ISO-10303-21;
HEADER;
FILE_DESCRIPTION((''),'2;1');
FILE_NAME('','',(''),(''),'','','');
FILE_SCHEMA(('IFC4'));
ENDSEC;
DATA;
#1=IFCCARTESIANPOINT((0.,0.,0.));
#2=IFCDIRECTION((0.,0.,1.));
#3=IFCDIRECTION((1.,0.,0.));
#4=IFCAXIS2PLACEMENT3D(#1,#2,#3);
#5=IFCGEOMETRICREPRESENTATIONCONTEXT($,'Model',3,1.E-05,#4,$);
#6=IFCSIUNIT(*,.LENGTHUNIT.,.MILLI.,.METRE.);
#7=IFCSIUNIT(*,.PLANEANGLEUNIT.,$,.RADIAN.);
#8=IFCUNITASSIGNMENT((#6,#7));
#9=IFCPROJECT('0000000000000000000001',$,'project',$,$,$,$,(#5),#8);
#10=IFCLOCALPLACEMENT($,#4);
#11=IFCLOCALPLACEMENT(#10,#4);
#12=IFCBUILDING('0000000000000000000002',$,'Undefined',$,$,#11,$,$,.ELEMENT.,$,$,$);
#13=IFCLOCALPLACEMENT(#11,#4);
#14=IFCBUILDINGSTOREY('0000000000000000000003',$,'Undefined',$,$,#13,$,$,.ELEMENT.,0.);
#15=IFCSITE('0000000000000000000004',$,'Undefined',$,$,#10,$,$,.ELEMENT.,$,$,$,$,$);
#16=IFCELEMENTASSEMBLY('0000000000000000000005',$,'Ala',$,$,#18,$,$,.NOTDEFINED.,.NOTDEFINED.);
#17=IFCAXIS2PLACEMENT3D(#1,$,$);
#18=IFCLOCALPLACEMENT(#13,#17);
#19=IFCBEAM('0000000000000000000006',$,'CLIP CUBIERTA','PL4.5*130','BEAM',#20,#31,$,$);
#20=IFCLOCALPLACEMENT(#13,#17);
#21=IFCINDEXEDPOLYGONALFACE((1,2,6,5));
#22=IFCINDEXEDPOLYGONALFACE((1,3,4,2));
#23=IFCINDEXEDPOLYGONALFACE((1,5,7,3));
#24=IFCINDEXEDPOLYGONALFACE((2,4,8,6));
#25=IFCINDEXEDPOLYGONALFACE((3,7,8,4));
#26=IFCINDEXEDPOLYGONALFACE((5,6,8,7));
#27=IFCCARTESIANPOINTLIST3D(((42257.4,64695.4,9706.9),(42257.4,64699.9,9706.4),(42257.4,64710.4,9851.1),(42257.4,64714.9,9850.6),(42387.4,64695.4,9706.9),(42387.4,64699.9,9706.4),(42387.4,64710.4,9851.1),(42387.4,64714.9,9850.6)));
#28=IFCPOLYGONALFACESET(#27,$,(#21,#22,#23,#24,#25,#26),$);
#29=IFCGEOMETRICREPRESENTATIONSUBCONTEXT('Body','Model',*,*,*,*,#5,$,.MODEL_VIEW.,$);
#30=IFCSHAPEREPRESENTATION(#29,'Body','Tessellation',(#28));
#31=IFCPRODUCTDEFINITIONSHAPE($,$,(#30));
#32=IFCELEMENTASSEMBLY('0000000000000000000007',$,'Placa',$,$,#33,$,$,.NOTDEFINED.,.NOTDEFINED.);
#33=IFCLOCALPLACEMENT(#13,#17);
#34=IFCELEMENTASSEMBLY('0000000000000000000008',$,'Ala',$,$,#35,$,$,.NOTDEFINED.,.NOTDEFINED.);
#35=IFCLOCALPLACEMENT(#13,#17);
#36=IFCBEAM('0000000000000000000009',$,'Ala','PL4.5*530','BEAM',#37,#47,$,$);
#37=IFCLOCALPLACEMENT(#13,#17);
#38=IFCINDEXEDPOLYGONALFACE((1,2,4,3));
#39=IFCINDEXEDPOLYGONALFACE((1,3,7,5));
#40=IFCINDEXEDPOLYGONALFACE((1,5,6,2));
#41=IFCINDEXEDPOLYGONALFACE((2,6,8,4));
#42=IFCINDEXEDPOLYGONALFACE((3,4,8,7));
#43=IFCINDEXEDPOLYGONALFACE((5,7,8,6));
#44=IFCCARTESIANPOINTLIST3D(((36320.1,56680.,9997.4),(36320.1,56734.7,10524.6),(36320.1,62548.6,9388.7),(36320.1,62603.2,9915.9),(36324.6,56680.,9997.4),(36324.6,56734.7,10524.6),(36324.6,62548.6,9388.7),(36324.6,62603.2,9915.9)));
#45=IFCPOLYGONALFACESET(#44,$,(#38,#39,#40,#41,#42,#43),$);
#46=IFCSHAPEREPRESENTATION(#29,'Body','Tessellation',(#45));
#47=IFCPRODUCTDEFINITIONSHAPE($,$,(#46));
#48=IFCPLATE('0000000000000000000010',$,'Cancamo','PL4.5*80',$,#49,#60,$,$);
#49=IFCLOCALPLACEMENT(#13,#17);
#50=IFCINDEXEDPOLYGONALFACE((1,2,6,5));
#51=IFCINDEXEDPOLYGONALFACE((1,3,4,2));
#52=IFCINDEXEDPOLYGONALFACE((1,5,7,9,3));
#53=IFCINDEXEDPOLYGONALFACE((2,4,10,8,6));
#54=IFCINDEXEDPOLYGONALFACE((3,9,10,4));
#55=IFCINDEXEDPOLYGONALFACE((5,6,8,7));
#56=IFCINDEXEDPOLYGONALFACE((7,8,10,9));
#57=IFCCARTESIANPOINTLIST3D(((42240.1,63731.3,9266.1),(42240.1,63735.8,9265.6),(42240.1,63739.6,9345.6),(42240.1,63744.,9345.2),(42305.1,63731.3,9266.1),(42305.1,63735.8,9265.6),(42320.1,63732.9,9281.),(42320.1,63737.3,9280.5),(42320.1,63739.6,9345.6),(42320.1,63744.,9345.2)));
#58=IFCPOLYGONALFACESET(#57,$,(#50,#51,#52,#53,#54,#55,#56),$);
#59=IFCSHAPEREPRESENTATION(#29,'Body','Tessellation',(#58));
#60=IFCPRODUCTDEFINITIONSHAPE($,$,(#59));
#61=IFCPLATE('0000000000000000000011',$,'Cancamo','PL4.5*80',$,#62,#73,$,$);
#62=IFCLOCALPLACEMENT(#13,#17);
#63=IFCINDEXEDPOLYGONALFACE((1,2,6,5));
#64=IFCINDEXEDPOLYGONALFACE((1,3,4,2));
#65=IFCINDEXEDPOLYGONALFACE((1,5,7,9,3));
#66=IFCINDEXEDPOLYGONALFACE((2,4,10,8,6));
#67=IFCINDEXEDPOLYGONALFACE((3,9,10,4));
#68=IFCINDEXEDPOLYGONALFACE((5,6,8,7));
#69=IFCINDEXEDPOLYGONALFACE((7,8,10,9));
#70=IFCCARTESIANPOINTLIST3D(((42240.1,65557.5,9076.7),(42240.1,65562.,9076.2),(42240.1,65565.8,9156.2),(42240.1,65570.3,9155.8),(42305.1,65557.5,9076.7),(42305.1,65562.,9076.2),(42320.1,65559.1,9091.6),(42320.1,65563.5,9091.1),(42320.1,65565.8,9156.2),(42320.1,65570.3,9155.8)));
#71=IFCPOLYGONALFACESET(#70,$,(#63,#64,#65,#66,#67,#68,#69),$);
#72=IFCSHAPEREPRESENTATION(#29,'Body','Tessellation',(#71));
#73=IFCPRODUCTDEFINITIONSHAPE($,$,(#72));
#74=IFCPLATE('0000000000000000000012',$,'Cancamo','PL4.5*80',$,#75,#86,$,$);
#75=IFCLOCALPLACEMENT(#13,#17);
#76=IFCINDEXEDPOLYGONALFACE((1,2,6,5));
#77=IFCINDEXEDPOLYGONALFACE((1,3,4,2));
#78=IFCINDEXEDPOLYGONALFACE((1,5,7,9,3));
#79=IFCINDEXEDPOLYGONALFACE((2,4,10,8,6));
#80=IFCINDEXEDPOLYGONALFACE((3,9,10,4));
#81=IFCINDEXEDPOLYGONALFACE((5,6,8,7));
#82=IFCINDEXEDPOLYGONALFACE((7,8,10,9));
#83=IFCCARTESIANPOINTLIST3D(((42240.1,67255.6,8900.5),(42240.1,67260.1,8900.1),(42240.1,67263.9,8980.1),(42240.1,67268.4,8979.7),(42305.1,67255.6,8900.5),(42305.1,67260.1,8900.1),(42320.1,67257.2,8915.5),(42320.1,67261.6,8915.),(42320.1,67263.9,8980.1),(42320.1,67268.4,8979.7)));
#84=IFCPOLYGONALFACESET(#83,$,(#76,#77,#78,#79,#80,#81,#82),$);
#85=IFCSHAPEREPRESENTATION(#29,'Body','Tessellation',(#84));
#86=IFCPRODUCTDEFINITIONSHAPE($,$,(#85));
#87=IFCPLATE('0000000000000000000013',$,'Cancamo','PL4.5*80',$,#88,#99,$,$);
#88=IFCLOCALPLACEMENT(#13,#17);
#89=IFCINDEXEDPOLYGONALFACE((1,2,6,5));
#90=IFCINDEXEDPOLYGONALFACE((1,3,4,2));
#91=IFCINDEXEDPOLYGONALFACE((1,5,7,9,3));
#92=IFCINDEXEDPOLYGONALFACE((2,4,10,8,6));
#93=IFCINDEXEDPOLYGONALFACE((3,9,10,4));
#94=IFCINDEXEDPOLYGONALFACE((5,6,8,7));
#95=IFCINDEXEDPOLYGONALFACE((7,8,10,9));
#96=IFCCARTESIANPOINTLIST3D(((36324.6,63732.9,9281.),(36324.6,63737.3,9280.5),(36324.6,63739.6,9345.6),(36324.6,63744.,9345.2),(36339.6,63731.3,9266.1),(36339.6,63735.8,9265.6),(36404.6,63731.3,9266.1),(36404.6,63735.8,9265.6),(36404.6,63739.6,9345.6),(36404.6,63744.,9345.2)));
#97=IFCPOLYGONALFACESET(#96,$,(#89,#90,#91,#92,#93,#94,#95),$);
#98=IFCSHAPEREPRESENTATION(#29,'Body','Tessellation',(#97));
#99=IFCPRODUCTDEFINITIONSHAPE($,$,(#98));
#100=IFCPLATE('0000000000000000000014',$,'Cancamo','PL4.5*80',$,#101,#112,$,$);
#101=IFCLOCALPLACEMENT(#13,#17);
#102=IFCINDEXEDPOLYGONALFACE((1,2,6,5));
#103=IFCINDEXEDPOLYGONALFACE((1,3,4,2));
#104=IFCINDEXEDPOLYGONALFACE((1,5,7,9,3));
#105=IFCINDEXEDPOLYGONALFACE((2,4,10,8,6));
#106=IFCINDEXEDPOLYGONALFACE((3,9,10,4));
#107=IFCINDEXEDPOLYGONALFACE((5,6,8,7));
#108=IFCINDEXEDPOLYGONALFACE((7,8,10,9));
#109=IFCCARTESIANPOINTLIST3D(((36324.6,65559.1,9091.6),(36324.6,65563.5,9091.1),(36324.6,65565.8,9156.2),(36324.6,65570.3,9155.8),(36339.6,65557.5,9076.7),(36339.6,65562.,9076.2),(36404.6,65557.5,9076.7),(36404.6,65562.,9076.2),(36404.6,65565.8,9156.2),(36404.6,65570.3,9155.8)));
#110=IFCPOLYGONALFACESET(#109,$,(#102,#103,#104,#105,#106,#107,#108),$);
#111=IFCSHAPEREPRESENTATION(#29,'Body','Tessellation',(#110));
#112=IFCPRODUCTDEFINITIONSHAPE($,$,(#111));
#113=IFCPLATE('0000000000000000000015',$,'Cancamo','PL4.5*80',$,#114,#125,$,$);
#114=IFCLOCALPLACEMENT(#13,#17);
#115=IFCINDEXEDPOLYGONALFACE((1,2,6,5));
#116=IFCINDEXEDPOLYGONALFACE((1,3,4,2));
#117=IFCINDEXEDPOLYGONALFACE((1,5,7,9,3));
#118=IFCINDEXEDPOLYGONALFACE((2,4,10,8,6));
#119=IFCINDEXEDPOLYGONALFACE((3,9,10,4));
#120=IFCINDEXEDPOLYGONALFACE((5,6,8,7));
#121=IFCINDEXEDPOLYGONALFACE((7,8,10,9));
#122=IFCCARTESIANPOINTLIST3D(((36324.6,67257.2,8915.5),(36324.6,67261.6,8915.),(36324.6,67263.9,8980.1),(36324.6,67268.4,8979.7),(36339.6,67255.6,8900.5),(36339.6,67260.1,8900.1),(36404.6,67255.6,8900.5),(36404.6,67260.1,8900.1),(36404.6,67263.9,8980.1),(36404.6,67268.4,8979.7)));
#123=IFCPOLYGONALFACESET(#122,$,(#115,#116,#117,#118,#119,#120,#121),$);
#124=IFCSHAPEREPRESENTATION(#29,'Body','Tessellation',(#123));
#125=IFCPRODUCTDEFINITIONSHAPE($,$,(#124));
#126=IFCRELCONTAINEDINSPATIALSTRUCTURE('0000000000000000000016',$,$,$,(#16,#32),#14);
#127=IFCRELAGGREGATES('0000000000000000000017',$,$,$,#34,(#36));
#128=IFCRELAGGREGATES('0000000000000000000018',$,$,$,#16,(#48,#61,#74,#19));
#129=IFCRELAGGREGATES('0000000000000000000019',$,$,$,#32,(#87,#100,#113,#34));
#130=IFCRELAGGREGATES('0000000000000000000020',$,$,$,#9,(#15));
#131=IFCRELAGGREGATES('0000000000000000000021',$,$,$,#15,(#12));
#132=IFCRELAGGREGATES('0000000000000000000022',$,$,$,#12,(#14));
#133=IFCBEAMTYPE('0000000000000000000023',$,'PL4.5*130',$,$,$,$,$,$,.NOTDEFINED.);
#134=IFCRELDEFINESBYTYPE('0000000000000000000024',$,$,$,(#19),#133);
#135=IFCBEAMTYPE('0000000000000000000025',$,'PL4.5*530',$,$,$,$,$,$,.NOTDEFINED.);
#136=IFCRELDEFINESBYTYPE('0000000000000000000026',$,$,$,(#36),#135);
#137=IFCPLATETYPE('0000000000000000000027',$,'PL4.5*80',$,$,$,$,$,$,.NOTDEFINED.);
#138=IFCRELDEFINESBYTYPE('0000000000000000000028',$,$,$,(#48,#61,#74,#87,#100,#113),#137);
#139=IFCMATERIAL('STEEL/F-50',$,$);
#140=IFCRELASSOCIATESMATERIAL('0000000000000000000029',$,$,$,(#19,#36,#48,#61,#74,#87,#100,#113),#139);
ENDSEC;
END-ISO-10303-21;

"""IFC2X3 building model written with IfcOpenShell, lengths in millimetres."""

from ifc_helpers import new_model, si_unit, frame, origin_with_axes, origin_2d_with_axis, place, context, subcontext, project, spatial, polyline, rectangle, outline, extrude, clip, halfspace, material, type_object, element, aggregate, save


model = new_model("IFC2X3")

# Units and contexts
model_context = context("Model", 3, precision=1e-05, world=origin_with_axes())
body_context = subcontext(model_context, "Body", "Model", "MODEL_VIEW")
ifc_project = project(units=[si_unit("LENGTHUNIT", "METRE", prefix="MILLI"), si_unit("PLANEANGLEUNIT", "RADIAN")], contexts=[model_context])

# Site, building, storey
site_placement = place(None, origin_with_axes())
site = spatial("IfcSite", under=ifc_project, at=site_placement, Name="Undefined", CompositionType="ELEMENT")
building_placement = place(site_placement, origin_with_axes())
building = spatial("IfcBuilding", under=site, at=building_placement, Name="Undefined", CompositionType="ELEMENT")
storey_placement = place(building_placement, origin_with_axes())
storey = spatial("IfcBuildingStorey", under=building, at=storey_placement, Name="Undefined", CompositionType="ELEMENT", Elevation=0.0)

# Element assembly, beam
assembly_1_placement = place(storey_placement, origin_with_axes())
assembly_1 = element("IfcElementAssembly", 1, at=assembly_1_placement, inside=storey, Name="Ala", AssemblyPlace="NOTDEFINED", PredefinedType="NOTDEFINED")
ifc_material_1 = material(Name="STEEL/F-50")
beam_type_1 = type_object("IfcBeamType", Name="PL4.5*130", PredefinedType="NOTDEFINED")
beam_1_placement = place(assembly_1_placement, frame((42322.4, 64697.7, 9706.6), z_axis=(-1.0, 0.0, 0.0), x_axis=(0.0, 0.103162, 0.994665)))
beam_1 = element("IfcBeam", 2, at=beam_1_placement, type_object=beam_type_1, material=ifc_material_1, Name="CLIP CUBIERTA", Description="PL4.5*130", ObjectType="BEAM", context=body_context, shape_type="SweptSolid", body=[
    extrude(rectangle(XDim=4.5, YDim=130.0, at=origin_2d_with_axis()), frame((145.0, 0.0, 0.0), z_axis=(-1.0, 0.0, 0.0), x_axis=(0.0, -1.0, 0.0)), (0.0, 0.0, 1.0), 145.0),
])

# Element assemblies, beam
assembly_2_placement = place(storey_placement, origin_with_axes())
assembly_2 = element("IfcElementAssembly", 3, at=assembly_2_placement, inside=storey, Name="Placa", AssemblyPlace="NOTDEFINED", PredefinedType="NOTDEFINED")
assembly_3_placement = place(assembly_2_placement, origin_with_axes())
assembly_3 = element("IfcElementAssembly", 4, at=assembly_3_placement, Name="Ala", AssemblyPlace="NOTDEFINED", PredefinedType="NOTDEFINED")
beam_type_2 = type_object("IfcBeamType", Name="PL4.5*530", PredefinedType="NOTDEFINED")
beam_2_placement = place(assembly_3_placement, frame((36322.4, 62575.9, 9652.3), z_axis=(0.0, 0.10316, 0.994665), x_axis=(0.0, -0.994665, 0.10316)))
beam_2 = element("IfcBeam", 5, at=beam_2_placement, type_object=beam_type_2, material=ifc_material_1, Name="Ala", Description="PL4.5*530", ObjectType="BEAM", context=body_context, shape_type="Clipping", body=[
    clip(extrude(rectangle(XDim=4.5, YDim=530.0, at=origin_2d_with_axis()), frame((6009.8, 0.0, 0.0), z_axis=(-1.0, 0.0, 0.0), x_axis=(0.0, -1.0, 0.0)), (0.0, 0.0, 1.0), 6009.9), halfspace(frame((5900.0, 0.0, 0.0), z_axis=(-1.0, 0.0, -0.000002), x_axis=(0.0, 1.0, 0.0)), True)),
])
aggregate(assembly_3, [beam_2])

# Plates
plate_type = type_object("IfcPlateType", Name="PL4.5*80", PredefinedType="NOTDEFINED")
plate_1_placement = place(assembly_1_placement, frame((42240.1, 63733.6, 9265.8), z_axis=(0.0, -0.994665, 0.103162), x_axis=(1.0, 0.0, 0.0)))
plate_1 = element("IfcPlate", 6, at=plate_1_placement, type_object=plate_type, material=ifc_material_1, Name="Cancamo", Description="PL4.5*80", context=body_context, shape_type="SweptSolid", body=[
    extrude(outline(polyline([(0.0, 0.0), (65.0, 0.0), (80.0, 15.0), (80.0, 80.0), (0.0, 80.0), (0.0, 0.0)])), frame((0.0, 0.0, -2.2), z_axis=(0.0, 0.0, 1.0), x_axis=(1.0, 0.0, 0.0)), (0.0, 0.0, 1.0), 4.5),
])
plate_2_placement = place(assembly_1_placement, frame((42240.1, 65559.8, 9076.4), z_axis=(0.0, -0.994665, 0.103162), x_axis=(1.0, 0.0, 0.0)))
plate_2 = element("IfcPlate", 7, at=plate_2_placement, type_object=plate_type, material=ifc_material_1, Name="Cancamo", Description="PL4.5*80", context=body_context, shape_type="SweptSolid", body=[
    extrude(outline(polyline([(0.0, 0.0), (65.0, 0.0), (80.0, 15.0), (80.0, 80.0), (0.0, 80.0), (0.0, 0.0)])), frame((0.0, 0.0, -2.2), z_axis=(0.0, 0.0, 1.0), x_axis=(1.0, 0.0, 0.0)), (0.0, 0.0, 1.0), 4.5),
])
plate_3_placement = place(assembly_1_placement, frame((42240.1, 67257.9, 8900.3), z_axis=(0.0, -0.994665, 0.103162), x_axis=(1.0, 0.0, 0.0)))
plate_3 = element("IfcPlate", 8, at=plate_3_placement, type_object=plate_type, material=ifc_material_1, Name="Cancamo", Description="PL4.5*80", context=body_context, shape_type="SweptSolid", body=[
    extrude(outline(polyline([(0.0, 0.0), (65.0, 0.0), (80.0, 15.0), (80.0, 80.0), (0.0, 80.0), (0.0, 0.0)])), frame((0.0, 0.0, -2.2), z_axis=(0.0, 0.0, 1.0), x_axis=(1.0, 0.0, 0.0)), (0.0, 0.0, 1.0), 4.5),
])
aggregate(assembly_1, [plate_1, plate_2, plate_3, beam_1])
plate_4_placement = place(assembly_2_placement, frame((36404.6, 63733.6, 9265.8), z_axis=(0.0, 0.994665, -0.103162), x_axis=(-1.0, 0.0, 0.0)))
plate_4 = element("IfcPlate", 9, at=plate_4_placement, type_object=plate_type, material=ifc_material_1, Name="Cancamo", Description="PL4.5*80", context=body_context, shape_type="SweptSolid", body=[
    extrude(outline(polyline([(0.0, 0.0), (65.0, 0.0), (80.0, 15.0), (80.0, 80.0), (0.0, 80.0), (0.0, 0.0)])), frame((0.0, 0.0, -2.2), z_axis=(0.0, 0.0, 1.0), x_axis=(1.0, 0.0, 0.0)), (0.0, 0.0, 1.0), 4.5),
])
plate_5_placement = place(assembly_2_placement, frame((36404.6, 65559.8, 9076.4), z_axis=(0.0, 0.994665, -0.103162), x_axis=(-1.0, 0.0, 0.0)))
plate_5 = element("IfcPlate", 10, at=plate_5_placement, type_object=plate_type, material=ifc_material_1, Name="Cancamo", Description="PL4.5*80", context=body_context, shape_type="SweptSolid", body=[
    extrude(outline(polyline([(0.0, 0.0), (65.0, 0.0), (80.0, 15.0), (80.0, 80.0), (0.0, 80.0), (0.0, 0.0)])), frame((0.0, 0.0, -2.2), z_axis=(0.0, 0.0, 1.0), x_axis=(1.0, 0.0, 0.0)), (0.0, 0.0, 1.0), 4.5),
])
plate_6_placement = place(assembly_2_placement, frame((36404.6, 67257.9, 8900.3), z_axis=(0.0, 0.994665, -0.103162), x_axis=(-1.0, 0.0, 0.0)))
plate_6 = element("IfcPlate", 11, at=plate_6_placement, type_object=plate_type, material=ifc_material_1, Name="Cancamo", Description="PL4.5*80", context=body_context, shape_type="SweptSolid", body=[
    extrude(outline(polyline([(0.0, 0.0), (65.0, 0.0), (80.0, 15.0), (80.0, 80.0), (0.0, 80.0), (0.0, 0.0)])), frame((0.0, 0.0, -2.2), z_axis=(0.0, 0.0, 1.0), x_axis=(1.0, 0.0, 0.0)), (0.0, 0.0, 1.0), 4.5),
])
aggregate(assembly_2, [plate_4, plate_5, plate_6, assembly_3])

save(model, "model.ifc")
